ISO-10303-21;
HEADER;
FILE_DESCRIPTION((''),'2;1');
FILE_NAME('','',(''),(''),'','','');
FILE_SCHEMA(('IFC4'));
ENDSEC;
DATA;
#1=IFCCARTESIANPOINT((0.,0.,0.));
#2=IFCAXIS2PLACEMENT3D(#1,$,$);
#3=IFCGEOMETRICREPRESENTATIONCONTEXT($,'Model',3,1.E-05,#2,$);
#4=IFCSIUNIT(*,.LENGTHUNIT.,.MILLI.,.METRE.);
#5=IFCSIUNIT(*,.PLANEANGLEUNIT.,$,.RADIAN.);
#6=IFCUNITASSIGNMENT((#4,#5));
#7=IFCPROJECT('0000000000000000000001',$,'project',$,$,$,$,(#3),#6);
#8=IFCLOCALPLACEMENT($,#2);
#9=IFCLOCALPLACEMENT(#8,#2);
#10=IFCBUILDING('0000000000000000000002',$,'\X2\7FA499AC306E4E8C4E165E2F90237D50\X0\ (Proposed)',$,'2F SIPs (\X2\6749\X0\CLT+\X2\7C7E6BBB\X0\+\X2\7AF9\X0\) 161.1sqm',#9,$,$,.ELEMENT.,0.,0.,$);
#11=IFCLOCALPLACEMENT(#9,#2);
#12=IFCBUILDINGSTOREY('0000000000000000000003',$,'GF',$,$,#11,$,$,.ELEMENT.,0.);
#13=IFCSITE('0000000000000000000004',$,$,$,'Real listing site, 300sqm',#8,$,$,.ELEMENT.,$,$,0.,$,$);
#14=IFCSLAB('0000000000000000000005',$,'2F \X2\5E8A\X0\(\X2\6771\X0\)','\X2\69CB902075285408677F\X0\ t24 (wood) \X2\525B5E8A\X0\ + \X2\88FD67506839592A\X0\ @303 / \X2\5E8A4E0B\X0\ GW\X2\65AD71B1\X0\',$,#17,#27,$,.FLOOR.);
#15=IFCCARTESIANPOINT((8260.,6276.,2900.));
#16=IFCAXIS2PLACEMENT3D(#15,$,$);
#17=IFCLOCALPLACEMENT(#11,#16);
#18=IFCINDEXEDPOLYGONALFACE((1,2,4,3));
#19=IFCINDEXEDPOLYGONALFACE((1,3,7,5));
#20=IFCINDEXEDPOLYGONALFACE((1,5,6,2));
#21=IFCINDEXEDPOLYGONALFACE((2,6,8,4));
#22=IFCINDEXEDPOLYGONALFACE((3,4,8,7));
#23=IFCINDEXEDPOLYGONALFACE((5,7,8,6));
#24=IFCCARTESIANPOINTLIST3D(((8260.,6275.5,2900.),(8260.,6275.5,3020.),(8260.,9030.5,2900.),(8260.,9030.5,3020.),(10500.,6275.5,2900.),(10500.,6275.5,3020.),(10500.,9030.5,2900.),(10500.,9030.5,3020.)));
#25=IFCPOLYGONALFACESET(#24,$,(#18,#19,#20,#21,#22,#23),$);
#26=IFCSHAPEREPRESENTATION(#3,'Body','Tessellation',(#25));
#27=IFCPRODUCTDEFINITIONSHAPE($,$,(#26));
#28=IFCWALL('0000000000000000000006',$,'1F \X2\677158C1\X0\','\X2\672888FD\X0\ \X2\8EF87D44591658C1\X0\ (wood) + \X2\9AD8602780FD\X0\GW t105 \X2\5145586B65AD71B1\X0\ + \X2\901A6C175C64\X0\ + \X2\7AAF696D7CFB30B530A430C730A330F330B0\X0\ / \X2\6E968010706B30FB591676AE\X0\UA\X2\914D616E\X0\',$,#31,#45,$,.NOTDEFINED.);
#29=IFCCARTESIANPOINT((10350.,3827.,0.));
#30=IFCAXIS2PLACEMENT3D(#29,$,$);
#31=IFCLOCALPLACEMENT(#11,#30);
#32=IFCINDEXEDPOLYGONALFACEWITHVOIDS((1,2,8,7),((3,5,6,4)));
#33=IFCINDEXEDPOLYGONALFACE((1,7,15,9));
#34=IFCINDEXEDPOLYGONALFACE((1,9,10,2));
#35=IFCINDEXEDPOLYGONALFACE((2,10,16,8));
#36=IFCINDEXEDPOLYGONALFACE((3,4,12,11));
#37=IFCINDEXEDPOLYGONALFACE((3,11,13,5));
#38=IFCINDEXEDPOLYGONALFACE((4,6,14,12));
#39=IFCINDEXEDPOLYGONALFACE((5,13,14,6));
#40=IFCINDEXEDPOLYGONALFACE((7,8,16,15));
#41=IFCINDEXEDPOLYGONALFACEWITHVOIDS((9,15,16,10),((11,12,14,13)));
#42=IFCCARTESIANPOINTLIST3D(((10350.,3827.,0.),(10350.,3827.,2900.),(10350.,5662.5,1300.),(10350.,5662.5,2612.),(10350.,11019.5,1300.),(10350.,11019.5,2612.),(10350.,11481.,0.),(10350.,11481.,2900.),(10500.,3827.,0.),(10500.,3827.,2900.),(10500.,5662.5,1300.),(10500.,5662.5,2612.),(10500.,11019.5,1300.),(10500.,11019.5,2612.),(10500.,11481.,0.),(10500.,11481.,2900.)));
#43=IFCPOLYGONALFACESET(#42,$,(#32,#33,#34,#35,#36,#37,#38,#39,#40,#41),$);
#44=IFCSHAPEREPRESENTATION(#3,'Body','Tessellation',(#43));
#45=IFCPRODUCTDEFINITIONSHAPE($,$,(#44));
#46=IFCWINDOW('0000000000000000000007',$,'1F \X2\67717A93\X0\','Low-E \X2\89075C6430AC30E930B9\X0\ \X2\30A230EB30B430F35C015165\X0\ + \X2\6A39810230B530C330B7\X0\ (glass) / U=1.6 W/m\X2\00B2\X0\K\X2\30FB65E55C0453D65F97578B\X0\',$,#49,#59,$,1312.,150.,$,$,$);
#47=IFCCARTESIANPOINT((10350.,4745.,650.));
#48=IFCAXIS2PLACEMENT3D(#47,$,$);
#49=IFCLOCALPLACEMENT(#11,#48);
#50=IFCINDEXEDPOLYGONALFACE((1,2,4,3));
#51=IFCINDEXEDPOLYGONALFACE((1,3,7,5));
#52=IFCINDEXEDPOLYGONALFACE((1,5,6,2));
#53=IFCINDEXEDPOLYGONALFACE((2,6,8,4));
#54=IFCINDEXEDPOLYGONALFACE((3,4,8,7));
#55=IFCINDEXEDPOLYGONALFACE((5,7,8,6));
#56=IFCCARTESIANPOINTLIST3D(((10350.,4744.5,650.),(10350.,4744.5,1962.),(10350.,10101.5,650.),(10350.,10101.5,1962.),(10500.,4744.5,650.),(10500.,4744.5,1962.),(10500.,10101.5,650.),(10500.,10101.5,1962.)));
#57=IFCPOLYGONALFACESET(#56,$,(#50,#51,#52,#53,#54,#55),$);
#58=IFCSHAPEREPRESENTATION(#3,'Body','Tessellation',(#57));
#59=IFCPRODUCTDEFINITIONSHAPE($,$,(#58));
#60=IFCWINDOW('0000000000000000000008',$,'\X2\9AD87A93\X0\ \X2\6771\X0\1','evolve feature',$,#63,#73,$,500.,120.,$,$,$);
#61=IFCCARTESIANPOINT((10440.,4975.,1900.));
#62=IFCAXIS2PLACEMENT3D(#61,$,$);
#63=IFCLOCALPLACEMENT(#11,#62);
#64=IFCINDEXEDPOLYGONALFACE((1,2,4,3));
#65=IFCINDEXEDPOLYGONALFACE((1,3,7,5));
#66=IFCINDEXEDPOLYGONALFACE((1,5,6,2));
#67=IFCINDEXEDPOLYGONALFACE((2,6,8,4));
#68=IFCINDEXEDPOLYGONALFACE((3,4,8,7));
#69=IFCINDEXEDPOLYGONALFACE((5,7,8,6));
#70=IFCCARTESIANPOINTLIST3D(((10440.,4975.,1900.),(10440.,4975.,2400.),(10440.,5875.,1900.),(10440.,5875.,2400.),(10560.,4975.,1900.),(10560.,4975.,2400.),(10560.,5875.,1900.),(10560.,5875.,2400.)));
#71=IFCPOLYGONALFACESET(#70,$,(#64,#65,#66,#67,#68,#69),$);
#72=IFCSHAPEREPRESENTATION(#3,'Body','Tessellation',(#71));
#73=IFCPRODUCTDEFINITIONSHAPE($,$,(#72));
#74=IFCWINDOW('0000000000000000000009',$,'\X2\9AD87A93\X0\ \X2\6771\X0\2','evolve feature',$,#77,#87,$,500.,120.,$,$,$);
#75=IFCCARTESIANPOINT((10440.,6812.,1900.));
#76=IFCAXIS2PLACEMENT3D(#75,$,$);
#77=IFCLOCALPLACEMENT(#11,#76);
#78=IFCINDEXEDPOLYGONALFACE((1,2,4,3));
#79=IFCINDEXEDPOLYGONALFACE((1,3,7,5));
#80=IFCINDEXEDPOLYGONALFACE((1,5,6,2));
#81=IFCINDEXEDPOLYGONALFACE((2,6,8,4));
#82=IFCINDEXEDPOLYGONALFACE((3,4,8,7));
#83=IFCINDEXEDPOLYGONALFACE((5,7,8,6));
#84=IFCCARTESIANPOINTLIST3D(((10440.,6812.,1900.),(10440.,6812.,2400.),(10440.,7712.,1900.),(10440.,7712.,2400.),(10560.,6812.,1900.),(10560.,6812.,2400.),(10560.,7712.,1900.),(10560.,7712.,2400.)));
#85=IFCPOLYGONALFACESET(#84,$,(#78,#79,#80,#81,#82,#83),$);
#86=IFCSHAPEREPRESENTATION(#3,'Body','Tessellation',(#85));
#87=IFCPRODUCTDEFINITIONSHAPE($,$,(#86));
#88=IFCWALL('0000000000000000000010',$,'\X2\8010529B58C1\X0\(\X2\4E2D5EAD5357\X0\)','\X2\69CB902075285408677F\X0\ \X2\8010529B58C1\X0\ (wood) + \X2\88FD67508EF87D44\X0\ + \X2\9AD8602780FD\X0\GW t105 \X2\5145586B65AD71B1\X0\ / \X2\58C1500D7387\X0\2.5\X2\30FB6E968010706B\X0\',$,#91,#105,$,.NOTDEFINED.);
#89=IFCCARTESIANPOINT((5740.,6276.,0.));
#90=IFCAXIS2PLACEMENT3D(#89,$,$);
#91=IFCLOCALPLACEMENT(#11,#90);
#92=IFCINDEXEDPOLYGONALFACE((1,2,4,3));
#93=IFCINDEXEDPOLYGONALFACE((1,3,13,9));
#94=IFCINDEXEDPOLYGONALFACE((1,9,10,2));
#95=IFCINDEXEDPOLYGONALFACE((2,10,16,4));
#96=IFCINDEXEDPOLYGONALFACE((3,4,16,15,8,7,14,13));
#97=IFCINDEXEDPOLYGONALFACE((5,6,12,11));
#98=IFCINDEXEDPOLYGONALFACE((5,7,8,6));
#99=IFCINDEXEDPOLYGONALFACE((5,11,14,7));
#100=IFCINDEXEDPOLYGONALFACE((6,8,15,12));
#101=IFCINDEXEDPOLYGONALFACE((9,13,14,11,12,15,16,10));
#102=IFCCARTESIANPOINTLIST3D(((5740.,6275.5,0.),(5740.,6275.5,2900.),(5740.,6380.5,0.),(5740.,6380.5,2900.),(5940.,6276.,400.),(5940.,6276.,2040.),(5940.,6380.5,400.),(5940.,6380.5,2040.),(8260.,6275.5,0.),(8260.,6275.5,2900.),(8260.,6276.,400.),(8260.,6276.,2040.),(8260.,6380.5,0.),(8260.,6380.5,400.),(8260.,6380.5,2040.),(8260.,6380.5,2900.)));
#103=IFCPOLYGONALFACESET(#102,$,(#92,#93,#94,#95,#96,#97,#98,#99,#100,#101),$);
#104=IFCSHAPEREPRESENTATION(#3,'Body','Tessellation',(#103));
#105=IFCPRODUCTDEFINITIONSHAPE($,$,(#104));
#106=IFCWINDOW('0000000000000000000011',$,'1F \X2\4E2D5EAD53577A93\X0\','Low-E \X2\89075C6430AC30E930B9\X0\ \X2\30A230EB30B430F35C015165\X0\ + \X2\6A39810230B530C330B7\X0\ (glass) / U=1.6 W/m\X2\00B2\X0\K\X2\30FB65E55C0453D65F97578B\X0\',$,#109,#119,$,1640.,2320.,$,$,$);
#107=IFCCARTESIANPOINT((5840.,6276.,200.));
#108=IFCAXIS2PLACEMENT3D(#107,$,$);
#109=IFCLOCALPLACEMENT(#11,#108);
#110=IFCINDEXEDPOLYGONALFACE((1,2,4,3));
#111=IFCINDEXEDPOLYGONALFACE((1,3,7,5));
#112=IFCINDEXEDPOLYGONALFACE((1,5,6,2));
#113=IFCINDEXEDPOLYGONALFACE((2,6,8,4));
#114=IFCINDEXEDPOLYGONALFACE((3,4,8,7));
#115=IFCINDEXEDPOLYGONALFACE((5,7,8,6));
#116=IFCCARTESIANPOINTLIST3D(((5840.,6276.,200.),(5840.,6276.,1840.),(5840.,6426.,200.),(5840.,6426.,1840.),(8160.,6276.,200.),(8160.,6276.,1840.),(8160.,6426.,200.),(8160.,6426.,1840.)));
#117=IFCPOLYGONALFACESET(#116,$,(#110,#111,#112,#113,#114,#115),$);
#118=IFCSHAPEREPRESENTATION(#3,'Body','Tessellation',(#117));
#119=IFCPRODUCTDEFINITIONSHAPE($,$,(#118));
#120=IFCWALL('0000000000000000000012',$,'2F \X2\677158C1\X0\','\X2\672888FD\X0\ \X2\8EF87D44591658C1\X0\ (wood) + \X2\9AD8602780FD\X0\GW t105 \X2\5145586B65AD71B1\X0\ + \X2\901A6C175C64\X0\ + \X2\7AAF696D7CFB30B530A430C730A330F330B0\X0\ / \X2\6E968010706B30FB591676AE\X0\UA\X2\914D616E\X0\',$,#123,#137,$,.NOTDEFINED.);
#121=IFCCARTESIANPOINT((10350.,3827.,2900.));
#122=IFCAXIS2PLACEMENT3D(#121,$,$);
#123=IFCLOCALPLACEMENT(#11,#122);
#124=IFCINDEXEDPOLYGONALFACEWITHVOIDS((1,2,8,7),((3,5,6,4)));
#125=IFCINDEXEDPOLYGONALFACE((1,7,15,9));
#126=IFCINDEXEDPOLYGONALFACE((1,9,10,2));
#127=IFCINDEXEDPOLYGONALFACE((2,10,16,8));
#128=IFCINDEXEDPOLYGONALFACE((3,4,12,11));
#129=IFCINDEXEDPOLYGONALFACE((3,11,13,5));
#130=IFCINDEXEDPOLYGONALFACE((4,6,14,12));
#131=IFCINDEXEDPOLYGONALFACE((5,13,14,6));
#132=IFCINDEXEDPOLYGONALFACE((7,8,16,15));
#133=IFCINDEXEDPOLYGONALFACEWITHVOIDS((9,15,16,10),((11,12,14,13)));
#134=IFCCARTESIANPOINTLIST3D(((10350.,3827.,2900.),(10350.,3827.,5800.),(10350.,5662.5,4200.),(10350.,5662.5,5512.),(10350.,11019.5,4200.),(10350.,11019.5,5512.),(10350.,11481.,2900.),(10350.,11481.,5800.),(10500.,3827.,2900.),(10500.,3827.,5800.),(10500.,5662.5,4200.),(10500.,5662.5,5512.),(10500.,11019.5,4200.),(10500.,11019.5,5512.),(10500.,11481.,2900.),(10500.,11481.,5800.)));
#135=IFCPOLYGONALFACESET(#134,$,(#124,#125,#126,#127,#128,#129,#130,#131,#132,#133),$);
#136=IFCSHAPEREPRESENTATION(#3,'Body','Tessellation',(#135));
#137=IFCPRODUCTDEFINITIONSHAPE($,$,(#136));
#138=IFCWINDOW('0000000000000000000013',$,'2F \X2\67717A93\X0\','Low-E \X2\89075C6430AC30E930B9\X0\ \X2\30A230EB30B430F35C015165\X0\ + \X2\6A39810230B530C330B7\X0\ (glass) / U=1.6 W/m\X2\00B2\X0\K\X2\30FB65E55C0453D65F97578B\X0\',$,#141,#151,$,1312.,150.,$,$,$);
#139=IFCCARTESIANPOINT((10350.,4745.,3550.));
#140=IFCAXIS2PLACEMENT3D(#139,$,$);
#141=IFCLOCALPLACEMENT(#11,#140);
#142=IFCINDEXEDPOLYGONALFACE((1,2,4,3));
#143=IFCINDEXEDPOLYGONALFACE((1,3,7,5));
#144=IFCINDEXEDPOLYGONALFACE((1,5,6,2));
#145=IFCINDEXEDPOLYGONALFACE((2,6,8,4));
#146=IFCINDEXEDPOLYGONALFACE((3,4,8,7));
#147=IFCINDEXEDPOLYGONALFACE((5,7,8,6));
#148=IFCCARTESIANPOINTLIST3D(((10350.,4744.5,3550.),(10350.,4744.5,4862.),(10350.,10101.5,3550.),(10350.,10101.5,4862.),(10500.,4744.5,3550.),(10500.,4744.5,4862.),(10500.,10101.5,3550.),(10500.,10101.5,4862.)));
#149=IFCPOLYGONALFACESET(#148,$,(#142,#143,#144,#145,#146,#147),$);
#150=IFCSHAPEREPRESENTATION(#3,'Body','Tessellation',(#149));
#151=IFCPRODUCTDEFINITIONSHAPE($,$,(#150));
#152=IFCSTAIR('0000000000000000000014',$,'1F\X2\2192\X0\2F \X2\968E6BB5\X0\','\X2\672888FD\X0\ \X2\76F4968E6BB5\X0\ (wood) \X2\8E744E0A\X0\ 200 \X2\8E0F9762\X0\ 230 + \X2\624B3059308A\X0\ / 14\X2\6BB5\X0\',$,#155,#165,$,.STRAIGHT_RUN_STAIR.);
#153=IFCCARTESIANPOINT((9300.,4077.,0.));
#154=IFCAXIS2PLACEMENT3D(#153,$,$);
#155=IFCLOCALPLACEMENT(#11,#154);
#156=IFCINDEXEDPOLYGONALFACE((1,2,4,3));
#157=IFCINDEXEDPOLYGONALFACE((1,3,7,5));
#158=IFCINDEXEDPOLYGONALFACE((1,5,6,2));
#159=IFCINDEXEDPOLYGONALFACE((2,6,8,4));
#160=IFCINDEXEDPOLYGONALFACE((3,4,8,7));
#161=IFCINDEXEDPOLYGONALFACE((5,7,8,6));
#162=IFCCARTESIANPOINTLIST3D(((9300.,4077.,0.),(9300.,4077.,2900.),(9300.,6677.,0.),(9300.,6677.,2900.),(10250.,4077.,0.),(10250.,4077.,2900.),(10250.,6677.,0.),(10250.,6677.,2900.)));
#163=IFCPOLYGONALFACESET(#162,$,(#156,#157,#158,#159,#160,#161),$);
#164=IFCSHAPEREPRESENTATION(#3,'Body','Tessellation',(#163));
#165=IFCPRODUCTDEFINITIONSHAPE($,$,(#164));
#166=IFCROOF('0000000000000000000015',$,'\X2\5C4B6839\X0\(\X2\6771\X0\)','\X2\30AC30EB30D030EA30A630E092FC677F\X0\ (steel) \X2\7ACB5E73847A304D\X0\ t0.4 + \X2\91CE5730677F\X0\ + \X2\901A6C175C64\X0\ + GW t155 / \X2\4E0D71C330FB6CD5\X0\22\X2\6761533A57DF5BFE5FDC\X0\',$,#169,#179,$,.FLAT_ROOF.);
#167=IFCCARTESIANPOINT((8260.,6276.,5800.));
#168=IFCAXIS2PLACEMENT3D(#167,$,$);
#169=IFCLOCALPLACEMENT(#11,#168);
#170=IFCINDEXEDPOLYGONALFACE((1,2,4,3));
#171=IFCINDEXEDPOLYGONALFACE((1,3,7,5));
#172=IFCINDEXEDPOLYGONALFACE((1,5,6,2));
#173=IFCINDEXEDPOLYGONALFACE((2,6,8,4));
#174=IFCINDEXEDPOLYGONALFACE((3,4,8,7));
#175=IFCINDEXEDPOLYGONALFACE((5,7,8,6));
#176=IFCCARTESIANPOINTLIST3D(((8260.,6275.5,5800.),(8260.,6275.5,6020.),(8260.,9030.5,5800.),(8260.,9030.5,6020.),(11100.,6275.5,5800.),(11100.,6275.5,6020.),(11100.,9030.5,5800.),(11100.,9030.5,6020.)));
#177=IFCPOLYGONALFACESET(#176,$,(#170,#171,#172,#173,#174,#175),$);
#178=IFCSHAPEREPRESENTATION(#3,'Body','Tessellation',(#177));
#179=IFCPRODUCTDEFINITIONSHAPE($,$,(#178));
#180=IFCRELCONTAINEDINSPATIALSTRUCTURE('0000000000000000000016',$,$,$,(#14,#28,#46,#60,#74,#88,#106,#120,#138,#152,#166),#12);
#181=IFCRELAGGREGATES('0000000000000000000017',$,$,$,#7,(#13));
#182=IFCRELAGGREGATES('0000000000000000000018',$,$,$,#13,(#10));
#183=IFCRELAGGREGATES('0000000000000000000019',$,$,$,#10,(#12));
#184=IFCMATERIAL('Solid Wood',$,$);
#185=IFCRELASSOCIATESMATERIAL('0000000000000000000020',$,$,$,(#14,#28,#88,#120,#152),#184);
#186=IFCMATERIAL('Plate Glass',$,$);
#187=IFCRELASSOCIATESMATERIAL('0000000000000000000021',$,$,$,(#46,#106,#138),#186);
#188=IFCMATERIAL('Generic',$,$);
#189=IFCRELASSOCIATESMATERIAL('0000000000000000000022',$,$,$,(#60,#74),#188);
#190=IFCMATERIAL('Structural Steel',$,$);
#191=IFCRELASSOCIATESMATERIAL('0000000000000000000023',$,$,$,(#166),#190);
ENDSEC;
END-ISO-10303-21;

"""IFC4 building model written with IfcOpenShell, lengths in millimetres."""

from ifc_helpers import new_model, si_unit, frame, frame_2d, origin, place, context, project, spatial, rectangle, extrude, material, element, fill, save


model = new_model("IFC4")

# Units and contexts
model_context = context("Model", 3, precision=1e-05, world=origin())
ifc_project = project(units=[si_unit("LENGTHUNIT", "METRE", prefix="MILLI"), si_unit("PLANEANGLEUNIT", "RADIAN")], contexts=[model_context])

# Site, building, storey
site_placement = place(None, origin())
site = spatial("IfcSite", under=ifc_project, at=site_placement, ObjectType="Real listing site, 300sqm", CompositionType="ELEMENT", RefElevation=0.0)
building_placement = place(site_placement, origin())
building = spatial("IfcBuilding", under=site, at=building_placement, Name="群馬の二世帯連結 (Proposed)", ObjectType="2F SIPs (杉CLT+籾殻+竹) 161.1sqm", CompositionType="ELEMENT", ElevationOfRefHeight=0.0, ElevationOfTerrain=0.0)
storey_placement = place(building_placement, origin())
storey = spatial("IfcBuildingStorey", under=building, at=storey_placement, Name="GF", CompositionType="ELEMENT", Elevation=0.0)

# Slab
ifc_material_1 = material(Name="Solid Wood")
slab_1_placement = place(storey_placement, frame((8260.0, 6276.0, 2900.0)))
element("IfcSlab", 1, at=slab_1_placement, inside=storey, material=ifc_material_1, Name="2F 床(東)", Description="構造用合板 t24 (wood) 剛床 + 製材根太 @303 / 床下 GW断熱", PredefinedType="FLOOR", context=model_context, shape_type="SweptSolid", body=[
    extrude(rectangle(XDim=2240.0, YDim=2755.0, at=frame_2d((1120.0, 1377.0))), frame((8260.0, 6276.0, 2900.0)), (0.0, 0.0, 1.0), 120.0),
])

# Wall, openings, windows
wall_1_placement = place(storey_placement, frame((10350.0, 3827.0, 0.0)))
wall_1 = element("IfcWall", 2, at=wall_1_placement, inside=storey, material=ifc_material_1, Name="1F 東壁", Description="木製 軸組外壁 (wood) + 高性能GW t105 充填断熱 + 通気層 + 窯業系サイディング / 準耐火・外皮UA配慮", PredefinedType="NOTDEFINED", context=model_context, shape_type="SweptSolid", body=[
    extrude(rectangle(XDim=150.0, YDim=7654.0, at=frame_2d((75.0, 3827.0))), frame((10350.0, 3827.0, 0.0)), (0.0, 0.0, 1.0), 2900.0),
])
opening_1_placement = place(storey_placement, frame((10350.0, 4745.0, 650.0)))
opening_1 = element("IfcOpeningElement", 3, at=opening_1_placement, cuts=wall_1, PredefinedType="NOTDEFINED", context=model_context, shape_type="SweptSolid", body=[
    extrude(rectangle(XDim=150.0, YDim=5357.0, at=frame_2d((75.0, 2678.0))), frame((10350.0, 4745.0, 650.0)), (0.0, 0.0, 1.0), 1312.0),
])
opening_2_placement = place(storey_placement, frame((10440.0, 4975.0, 1900.0)))
opening_2 = element("IfcOpeningElement", 4, at=opening_2_placement, cuts=wall_1, PredefinedType="NOTDEFINED", context=model_context, shape_type="SweptSolid", body=[
    extrude(rectangle(XDim=120.0, YDim=900.0, at=frame_2d((60.0, 450.0))), frame((10440.0, 4975.0, 1900.0)), (0.0, 0.0, 1.0), 500.0),
])
opening_3_placement = place(storey_placement, frame((10440.0, 6812.0, 1900.0)))
opening_3 = element("IfcOpeningElement", 5, at=opening_3_placement, cuts=wall_1, PredefinedType="NOTDEFINED", context=model_context, shape_type="SweptSolid", body=[
    extrude(rectangle(XDim=120.0, YDim=900.0, at=frame_2d((60.0, 450.0))), frame((10440.0, 6812.0, 1900.0)), (0.0, 0.0, 1.0), 500.0),
])
ifc_material_2 = material(Name="Plate Glass")
window_1_placement = place(storey_placement, frame((10350.0, 4745.0, 650.0)))
window_1 = element("IfcWindow", 6, at=window_1_placement, inside=storey, material=ifc_material_2, Name="1F 東窓", Description="Low-E 複層ガラス アルゴン封入 + 樹脂サッシ (glass) / U=1.6 W/m²K・日射取得型", OverallHeight=1312.0, OverallWidth=150.0, context=model_context, shape_type="SweptSolid", body=[
    extrude(rectangle(XDim=150.0, YDim=5357.0, at=frame_2d((75.0, 2678.0))), frame((10350.0, 4745.0, 650.0)), (0.0, 0.0, 1.0), 1312.0),
])
fill(opening_1, window_1)
ifc_material_3 = material(Name="Generic")
window_2_placement = place(storey_placement, frame((10440.0, 4975.0, 1900.0)))
window_2 = element("IfcWindow", 7, at=window_2_placement, inside=storey, material=ifc_material_3, Name="高窓 東1", Description="evolve feature", OverallHeight=500.0, OverallWidth=120.0, context=model_context, shape_type="SweptSolid", body=[
    extrude(rectangle(XDim=120.0, YDim=900.0, at=frame_2d((60.0, 450.0))), frame((10440.0, 4975.0, 1900.0)), (0.0, 0.0, 1.0), 500.0),
])
fill(opening_2, window_2)
window_3_placement = place(storey_placement, frame((10440.0, 6812.0, 1900.0)))
window_3 = element("IfcWindow", 8, at=window_3_placement, inside=storey, material=ifc_material_3, Name="高窓 東2", Description="evolve feature", OverallHeight=500.0, OverallWidth=120.0, context=model_context, shape_type="SweptSolid", body=[
    extrude(rectangle(XDim=120.0, YDim=900.0, at=frame_2d((60.0, 450.0))), frame((10440.0, 6812.0, 1900.0)), (0.0, 0.0, 1.0), 500.0),
])
fill(opening_3, window_3)

# Wall, opening, window
wall_2_placement = place(storey_placement, frame((5740.0, 6276.0, 0.0)))
wall_2 = element("IfcWall", 9, at=wall_2_placement, inside=storey, material=ifc_material_1, Name="耐力壁(中庭南)", Description="構造用合板 耐力壁 (wood) + 製材軸組 + 高性能GW t105 充填断熱 / 壁倍率2.5・準耐火", PredefinedType="NOTDEFINED", context=model_context, shape_type="SweptSolid", body=[
    extrude(rectangle(XDim=2520.0, YDim=105.0, at=frame_2d((1260.0, 52.0))), frame((5740.0, 6276.0, 0.0)), (0.0, 0.0, 1.0), 2900.0),
])
opening_4_placement = place(storey_placement, frame((5840.0, 6276.0, 200.0)))
opening_4 = element("IfcOpeningElement", 10, at=opening_4_placement, cuts=wall_2, PredefinedType="NOTDEFINED", context=model_context, shape_type="SweptSolid", body=[
    extrude(rectangle(XDim=2320.0, YDim=150.0, at=frame_2d((1160.0, 75.0))), frame((5840.0, 6276.0, 200.0)), (0.0, 0.0, 1.0), 1640.0),
])
window_4_placement = place(storey_placement, frame((5840.0, 6276.0, 200.0)))
window_4 = element("IfcWindow", 11, at=window_4_placement, inside=storey, material=ifc_material_2, Name="1F 中庭南窓", Description="Low-E 複層ガラス アルゴン封入 + 樹脂サッシ (glass) / U=1.6 W/m²K・日射取得型", OverallHeight=1640.0, OverallWidth=2320.0, context=model_context, shape_type="SweptSolid", body=[
    extrude(rectangle(XDim=2320.0, YDim=150.0, at=frame_2d((1160.0, 75.0))), frame((5840.0, 6276.0, 200.0)), (0.0, 0.0, 1.0), 1640.0),
])
fill(opening_4, window_4)

# Wall, opening, window
wall_3_placement = place(storey_placement, frame((10350.0, 3827.0, 2900.0)))
wall_3 = element("IfcWall", 12, at=wall_3_placement, inside=storey, material=ifc_material_1, Name="2F 東壁", Description="木製 軸組外壁 (wood) + 高性能GW t105 充填断熱 + 通気層 + 窯業系サイディング / 準耐火・外皮UA配慮", PredefinedType="NOTDEFINED", context=model_context, shape_type="SweptSolid", body=[
    extrude(rectangle(XDim=150.0, YDim=7654.0, at=frame_2d((75.0, 3827.0))), frame((10350.0, 3827.0, 2900.0)), (0.0, 0.0, 1.0), 2900.0),
])
opening_5_placement = place(storey_placement, frame((10350.0, 4745.0, 3550.0)))
opening_5 = element("IfcOpeningElement", 13, at=opening_5_placement, cuts=wall_3, PredefinedType="NOTDEFINED", context=model_context, shape_type="SweptSolid", body=[
    extrude(rectangle(XDim=150.0, YDim=5357.0, at=frame_2d((75.0, 2678.0))), frame((10350.0, 4745.0, 3550.0)), (0.0, 0.0, 1.0), 1312.0),
])
window_5_placement = place(storey_placement, frame((10350.0, 4745.0, 3550.0)))
window_5 = element("IfcWindow", 14, at=window_5_placement, inside=storey, material=ifc_material_2, Name="2F 東窓", Description="Low-E 複層ガラス アルゴン封入 + 樹脂サッシ (glass) / U=1.6 W/m²K・日射取得型", OverallHeight=1312.0, OverallWidth=150.0, context=model_context, shape_type="SweptSolid", body=[
    extrude(rectangle(XDim=150.0, YDim=5357.0, at=frame_2d((75.0, 2678.0))), frame((10350.0, 4745.0, 3550.0)), (0.0, 0.0, 1.0), 1312.0),
])
fill(opening_5, window_5)

# Stair
stair_placement = place(storey_placement, frame((9300.0, 4077.0, 0.0)))
element("IfcStair", 15, at=stair_placement, inside=storey, material=ifc_material_1, Name="1F→2F 階段", Description="木製 直階段 (wood) 蹴上 200 踏面 230 + 手すり / 14段", PredefinedType="STRAIGHT_RUN_STAIR", context=model_context, shape_type="SweptSolid", body=[
    extrude(rectangle(XDim=950.0, YDim=2600.0, at=frame_2d((475.0, 1300.0))), frame((9300.0, 4077.0, 0.0)), (0.0, 0.0, 1.0), 2900.0),
])

# Roof
ifc_material_4 = material(Name="Structural Steel")
roof_placement = place(storey_placement, frame((8260.0, 6276.0, 5800.0)))
element("IfcRoof", 16, at=roof_placement, inside=storey, material=ifc_material_4, Name="屋根(東)", Description="ガルバリウム鋼板 (steel) 立平葺き t0.4 + 野地板 + 通気層 + GW t155 / 不燃・法22条区域対応", PredefinedType="FLAT_ROOF", context=model_context, shape_type="SweptSolid", body=[
    extrude(rectangle(XDim=2840.0, YDim=2755.0, at=frame_2d((1420.0, 1377.0))), frame((8260.0, 6276.0, 5800.0)), (0.0, 0.0, 1.0), 220.0),
])

save(model, "model.ifc")
